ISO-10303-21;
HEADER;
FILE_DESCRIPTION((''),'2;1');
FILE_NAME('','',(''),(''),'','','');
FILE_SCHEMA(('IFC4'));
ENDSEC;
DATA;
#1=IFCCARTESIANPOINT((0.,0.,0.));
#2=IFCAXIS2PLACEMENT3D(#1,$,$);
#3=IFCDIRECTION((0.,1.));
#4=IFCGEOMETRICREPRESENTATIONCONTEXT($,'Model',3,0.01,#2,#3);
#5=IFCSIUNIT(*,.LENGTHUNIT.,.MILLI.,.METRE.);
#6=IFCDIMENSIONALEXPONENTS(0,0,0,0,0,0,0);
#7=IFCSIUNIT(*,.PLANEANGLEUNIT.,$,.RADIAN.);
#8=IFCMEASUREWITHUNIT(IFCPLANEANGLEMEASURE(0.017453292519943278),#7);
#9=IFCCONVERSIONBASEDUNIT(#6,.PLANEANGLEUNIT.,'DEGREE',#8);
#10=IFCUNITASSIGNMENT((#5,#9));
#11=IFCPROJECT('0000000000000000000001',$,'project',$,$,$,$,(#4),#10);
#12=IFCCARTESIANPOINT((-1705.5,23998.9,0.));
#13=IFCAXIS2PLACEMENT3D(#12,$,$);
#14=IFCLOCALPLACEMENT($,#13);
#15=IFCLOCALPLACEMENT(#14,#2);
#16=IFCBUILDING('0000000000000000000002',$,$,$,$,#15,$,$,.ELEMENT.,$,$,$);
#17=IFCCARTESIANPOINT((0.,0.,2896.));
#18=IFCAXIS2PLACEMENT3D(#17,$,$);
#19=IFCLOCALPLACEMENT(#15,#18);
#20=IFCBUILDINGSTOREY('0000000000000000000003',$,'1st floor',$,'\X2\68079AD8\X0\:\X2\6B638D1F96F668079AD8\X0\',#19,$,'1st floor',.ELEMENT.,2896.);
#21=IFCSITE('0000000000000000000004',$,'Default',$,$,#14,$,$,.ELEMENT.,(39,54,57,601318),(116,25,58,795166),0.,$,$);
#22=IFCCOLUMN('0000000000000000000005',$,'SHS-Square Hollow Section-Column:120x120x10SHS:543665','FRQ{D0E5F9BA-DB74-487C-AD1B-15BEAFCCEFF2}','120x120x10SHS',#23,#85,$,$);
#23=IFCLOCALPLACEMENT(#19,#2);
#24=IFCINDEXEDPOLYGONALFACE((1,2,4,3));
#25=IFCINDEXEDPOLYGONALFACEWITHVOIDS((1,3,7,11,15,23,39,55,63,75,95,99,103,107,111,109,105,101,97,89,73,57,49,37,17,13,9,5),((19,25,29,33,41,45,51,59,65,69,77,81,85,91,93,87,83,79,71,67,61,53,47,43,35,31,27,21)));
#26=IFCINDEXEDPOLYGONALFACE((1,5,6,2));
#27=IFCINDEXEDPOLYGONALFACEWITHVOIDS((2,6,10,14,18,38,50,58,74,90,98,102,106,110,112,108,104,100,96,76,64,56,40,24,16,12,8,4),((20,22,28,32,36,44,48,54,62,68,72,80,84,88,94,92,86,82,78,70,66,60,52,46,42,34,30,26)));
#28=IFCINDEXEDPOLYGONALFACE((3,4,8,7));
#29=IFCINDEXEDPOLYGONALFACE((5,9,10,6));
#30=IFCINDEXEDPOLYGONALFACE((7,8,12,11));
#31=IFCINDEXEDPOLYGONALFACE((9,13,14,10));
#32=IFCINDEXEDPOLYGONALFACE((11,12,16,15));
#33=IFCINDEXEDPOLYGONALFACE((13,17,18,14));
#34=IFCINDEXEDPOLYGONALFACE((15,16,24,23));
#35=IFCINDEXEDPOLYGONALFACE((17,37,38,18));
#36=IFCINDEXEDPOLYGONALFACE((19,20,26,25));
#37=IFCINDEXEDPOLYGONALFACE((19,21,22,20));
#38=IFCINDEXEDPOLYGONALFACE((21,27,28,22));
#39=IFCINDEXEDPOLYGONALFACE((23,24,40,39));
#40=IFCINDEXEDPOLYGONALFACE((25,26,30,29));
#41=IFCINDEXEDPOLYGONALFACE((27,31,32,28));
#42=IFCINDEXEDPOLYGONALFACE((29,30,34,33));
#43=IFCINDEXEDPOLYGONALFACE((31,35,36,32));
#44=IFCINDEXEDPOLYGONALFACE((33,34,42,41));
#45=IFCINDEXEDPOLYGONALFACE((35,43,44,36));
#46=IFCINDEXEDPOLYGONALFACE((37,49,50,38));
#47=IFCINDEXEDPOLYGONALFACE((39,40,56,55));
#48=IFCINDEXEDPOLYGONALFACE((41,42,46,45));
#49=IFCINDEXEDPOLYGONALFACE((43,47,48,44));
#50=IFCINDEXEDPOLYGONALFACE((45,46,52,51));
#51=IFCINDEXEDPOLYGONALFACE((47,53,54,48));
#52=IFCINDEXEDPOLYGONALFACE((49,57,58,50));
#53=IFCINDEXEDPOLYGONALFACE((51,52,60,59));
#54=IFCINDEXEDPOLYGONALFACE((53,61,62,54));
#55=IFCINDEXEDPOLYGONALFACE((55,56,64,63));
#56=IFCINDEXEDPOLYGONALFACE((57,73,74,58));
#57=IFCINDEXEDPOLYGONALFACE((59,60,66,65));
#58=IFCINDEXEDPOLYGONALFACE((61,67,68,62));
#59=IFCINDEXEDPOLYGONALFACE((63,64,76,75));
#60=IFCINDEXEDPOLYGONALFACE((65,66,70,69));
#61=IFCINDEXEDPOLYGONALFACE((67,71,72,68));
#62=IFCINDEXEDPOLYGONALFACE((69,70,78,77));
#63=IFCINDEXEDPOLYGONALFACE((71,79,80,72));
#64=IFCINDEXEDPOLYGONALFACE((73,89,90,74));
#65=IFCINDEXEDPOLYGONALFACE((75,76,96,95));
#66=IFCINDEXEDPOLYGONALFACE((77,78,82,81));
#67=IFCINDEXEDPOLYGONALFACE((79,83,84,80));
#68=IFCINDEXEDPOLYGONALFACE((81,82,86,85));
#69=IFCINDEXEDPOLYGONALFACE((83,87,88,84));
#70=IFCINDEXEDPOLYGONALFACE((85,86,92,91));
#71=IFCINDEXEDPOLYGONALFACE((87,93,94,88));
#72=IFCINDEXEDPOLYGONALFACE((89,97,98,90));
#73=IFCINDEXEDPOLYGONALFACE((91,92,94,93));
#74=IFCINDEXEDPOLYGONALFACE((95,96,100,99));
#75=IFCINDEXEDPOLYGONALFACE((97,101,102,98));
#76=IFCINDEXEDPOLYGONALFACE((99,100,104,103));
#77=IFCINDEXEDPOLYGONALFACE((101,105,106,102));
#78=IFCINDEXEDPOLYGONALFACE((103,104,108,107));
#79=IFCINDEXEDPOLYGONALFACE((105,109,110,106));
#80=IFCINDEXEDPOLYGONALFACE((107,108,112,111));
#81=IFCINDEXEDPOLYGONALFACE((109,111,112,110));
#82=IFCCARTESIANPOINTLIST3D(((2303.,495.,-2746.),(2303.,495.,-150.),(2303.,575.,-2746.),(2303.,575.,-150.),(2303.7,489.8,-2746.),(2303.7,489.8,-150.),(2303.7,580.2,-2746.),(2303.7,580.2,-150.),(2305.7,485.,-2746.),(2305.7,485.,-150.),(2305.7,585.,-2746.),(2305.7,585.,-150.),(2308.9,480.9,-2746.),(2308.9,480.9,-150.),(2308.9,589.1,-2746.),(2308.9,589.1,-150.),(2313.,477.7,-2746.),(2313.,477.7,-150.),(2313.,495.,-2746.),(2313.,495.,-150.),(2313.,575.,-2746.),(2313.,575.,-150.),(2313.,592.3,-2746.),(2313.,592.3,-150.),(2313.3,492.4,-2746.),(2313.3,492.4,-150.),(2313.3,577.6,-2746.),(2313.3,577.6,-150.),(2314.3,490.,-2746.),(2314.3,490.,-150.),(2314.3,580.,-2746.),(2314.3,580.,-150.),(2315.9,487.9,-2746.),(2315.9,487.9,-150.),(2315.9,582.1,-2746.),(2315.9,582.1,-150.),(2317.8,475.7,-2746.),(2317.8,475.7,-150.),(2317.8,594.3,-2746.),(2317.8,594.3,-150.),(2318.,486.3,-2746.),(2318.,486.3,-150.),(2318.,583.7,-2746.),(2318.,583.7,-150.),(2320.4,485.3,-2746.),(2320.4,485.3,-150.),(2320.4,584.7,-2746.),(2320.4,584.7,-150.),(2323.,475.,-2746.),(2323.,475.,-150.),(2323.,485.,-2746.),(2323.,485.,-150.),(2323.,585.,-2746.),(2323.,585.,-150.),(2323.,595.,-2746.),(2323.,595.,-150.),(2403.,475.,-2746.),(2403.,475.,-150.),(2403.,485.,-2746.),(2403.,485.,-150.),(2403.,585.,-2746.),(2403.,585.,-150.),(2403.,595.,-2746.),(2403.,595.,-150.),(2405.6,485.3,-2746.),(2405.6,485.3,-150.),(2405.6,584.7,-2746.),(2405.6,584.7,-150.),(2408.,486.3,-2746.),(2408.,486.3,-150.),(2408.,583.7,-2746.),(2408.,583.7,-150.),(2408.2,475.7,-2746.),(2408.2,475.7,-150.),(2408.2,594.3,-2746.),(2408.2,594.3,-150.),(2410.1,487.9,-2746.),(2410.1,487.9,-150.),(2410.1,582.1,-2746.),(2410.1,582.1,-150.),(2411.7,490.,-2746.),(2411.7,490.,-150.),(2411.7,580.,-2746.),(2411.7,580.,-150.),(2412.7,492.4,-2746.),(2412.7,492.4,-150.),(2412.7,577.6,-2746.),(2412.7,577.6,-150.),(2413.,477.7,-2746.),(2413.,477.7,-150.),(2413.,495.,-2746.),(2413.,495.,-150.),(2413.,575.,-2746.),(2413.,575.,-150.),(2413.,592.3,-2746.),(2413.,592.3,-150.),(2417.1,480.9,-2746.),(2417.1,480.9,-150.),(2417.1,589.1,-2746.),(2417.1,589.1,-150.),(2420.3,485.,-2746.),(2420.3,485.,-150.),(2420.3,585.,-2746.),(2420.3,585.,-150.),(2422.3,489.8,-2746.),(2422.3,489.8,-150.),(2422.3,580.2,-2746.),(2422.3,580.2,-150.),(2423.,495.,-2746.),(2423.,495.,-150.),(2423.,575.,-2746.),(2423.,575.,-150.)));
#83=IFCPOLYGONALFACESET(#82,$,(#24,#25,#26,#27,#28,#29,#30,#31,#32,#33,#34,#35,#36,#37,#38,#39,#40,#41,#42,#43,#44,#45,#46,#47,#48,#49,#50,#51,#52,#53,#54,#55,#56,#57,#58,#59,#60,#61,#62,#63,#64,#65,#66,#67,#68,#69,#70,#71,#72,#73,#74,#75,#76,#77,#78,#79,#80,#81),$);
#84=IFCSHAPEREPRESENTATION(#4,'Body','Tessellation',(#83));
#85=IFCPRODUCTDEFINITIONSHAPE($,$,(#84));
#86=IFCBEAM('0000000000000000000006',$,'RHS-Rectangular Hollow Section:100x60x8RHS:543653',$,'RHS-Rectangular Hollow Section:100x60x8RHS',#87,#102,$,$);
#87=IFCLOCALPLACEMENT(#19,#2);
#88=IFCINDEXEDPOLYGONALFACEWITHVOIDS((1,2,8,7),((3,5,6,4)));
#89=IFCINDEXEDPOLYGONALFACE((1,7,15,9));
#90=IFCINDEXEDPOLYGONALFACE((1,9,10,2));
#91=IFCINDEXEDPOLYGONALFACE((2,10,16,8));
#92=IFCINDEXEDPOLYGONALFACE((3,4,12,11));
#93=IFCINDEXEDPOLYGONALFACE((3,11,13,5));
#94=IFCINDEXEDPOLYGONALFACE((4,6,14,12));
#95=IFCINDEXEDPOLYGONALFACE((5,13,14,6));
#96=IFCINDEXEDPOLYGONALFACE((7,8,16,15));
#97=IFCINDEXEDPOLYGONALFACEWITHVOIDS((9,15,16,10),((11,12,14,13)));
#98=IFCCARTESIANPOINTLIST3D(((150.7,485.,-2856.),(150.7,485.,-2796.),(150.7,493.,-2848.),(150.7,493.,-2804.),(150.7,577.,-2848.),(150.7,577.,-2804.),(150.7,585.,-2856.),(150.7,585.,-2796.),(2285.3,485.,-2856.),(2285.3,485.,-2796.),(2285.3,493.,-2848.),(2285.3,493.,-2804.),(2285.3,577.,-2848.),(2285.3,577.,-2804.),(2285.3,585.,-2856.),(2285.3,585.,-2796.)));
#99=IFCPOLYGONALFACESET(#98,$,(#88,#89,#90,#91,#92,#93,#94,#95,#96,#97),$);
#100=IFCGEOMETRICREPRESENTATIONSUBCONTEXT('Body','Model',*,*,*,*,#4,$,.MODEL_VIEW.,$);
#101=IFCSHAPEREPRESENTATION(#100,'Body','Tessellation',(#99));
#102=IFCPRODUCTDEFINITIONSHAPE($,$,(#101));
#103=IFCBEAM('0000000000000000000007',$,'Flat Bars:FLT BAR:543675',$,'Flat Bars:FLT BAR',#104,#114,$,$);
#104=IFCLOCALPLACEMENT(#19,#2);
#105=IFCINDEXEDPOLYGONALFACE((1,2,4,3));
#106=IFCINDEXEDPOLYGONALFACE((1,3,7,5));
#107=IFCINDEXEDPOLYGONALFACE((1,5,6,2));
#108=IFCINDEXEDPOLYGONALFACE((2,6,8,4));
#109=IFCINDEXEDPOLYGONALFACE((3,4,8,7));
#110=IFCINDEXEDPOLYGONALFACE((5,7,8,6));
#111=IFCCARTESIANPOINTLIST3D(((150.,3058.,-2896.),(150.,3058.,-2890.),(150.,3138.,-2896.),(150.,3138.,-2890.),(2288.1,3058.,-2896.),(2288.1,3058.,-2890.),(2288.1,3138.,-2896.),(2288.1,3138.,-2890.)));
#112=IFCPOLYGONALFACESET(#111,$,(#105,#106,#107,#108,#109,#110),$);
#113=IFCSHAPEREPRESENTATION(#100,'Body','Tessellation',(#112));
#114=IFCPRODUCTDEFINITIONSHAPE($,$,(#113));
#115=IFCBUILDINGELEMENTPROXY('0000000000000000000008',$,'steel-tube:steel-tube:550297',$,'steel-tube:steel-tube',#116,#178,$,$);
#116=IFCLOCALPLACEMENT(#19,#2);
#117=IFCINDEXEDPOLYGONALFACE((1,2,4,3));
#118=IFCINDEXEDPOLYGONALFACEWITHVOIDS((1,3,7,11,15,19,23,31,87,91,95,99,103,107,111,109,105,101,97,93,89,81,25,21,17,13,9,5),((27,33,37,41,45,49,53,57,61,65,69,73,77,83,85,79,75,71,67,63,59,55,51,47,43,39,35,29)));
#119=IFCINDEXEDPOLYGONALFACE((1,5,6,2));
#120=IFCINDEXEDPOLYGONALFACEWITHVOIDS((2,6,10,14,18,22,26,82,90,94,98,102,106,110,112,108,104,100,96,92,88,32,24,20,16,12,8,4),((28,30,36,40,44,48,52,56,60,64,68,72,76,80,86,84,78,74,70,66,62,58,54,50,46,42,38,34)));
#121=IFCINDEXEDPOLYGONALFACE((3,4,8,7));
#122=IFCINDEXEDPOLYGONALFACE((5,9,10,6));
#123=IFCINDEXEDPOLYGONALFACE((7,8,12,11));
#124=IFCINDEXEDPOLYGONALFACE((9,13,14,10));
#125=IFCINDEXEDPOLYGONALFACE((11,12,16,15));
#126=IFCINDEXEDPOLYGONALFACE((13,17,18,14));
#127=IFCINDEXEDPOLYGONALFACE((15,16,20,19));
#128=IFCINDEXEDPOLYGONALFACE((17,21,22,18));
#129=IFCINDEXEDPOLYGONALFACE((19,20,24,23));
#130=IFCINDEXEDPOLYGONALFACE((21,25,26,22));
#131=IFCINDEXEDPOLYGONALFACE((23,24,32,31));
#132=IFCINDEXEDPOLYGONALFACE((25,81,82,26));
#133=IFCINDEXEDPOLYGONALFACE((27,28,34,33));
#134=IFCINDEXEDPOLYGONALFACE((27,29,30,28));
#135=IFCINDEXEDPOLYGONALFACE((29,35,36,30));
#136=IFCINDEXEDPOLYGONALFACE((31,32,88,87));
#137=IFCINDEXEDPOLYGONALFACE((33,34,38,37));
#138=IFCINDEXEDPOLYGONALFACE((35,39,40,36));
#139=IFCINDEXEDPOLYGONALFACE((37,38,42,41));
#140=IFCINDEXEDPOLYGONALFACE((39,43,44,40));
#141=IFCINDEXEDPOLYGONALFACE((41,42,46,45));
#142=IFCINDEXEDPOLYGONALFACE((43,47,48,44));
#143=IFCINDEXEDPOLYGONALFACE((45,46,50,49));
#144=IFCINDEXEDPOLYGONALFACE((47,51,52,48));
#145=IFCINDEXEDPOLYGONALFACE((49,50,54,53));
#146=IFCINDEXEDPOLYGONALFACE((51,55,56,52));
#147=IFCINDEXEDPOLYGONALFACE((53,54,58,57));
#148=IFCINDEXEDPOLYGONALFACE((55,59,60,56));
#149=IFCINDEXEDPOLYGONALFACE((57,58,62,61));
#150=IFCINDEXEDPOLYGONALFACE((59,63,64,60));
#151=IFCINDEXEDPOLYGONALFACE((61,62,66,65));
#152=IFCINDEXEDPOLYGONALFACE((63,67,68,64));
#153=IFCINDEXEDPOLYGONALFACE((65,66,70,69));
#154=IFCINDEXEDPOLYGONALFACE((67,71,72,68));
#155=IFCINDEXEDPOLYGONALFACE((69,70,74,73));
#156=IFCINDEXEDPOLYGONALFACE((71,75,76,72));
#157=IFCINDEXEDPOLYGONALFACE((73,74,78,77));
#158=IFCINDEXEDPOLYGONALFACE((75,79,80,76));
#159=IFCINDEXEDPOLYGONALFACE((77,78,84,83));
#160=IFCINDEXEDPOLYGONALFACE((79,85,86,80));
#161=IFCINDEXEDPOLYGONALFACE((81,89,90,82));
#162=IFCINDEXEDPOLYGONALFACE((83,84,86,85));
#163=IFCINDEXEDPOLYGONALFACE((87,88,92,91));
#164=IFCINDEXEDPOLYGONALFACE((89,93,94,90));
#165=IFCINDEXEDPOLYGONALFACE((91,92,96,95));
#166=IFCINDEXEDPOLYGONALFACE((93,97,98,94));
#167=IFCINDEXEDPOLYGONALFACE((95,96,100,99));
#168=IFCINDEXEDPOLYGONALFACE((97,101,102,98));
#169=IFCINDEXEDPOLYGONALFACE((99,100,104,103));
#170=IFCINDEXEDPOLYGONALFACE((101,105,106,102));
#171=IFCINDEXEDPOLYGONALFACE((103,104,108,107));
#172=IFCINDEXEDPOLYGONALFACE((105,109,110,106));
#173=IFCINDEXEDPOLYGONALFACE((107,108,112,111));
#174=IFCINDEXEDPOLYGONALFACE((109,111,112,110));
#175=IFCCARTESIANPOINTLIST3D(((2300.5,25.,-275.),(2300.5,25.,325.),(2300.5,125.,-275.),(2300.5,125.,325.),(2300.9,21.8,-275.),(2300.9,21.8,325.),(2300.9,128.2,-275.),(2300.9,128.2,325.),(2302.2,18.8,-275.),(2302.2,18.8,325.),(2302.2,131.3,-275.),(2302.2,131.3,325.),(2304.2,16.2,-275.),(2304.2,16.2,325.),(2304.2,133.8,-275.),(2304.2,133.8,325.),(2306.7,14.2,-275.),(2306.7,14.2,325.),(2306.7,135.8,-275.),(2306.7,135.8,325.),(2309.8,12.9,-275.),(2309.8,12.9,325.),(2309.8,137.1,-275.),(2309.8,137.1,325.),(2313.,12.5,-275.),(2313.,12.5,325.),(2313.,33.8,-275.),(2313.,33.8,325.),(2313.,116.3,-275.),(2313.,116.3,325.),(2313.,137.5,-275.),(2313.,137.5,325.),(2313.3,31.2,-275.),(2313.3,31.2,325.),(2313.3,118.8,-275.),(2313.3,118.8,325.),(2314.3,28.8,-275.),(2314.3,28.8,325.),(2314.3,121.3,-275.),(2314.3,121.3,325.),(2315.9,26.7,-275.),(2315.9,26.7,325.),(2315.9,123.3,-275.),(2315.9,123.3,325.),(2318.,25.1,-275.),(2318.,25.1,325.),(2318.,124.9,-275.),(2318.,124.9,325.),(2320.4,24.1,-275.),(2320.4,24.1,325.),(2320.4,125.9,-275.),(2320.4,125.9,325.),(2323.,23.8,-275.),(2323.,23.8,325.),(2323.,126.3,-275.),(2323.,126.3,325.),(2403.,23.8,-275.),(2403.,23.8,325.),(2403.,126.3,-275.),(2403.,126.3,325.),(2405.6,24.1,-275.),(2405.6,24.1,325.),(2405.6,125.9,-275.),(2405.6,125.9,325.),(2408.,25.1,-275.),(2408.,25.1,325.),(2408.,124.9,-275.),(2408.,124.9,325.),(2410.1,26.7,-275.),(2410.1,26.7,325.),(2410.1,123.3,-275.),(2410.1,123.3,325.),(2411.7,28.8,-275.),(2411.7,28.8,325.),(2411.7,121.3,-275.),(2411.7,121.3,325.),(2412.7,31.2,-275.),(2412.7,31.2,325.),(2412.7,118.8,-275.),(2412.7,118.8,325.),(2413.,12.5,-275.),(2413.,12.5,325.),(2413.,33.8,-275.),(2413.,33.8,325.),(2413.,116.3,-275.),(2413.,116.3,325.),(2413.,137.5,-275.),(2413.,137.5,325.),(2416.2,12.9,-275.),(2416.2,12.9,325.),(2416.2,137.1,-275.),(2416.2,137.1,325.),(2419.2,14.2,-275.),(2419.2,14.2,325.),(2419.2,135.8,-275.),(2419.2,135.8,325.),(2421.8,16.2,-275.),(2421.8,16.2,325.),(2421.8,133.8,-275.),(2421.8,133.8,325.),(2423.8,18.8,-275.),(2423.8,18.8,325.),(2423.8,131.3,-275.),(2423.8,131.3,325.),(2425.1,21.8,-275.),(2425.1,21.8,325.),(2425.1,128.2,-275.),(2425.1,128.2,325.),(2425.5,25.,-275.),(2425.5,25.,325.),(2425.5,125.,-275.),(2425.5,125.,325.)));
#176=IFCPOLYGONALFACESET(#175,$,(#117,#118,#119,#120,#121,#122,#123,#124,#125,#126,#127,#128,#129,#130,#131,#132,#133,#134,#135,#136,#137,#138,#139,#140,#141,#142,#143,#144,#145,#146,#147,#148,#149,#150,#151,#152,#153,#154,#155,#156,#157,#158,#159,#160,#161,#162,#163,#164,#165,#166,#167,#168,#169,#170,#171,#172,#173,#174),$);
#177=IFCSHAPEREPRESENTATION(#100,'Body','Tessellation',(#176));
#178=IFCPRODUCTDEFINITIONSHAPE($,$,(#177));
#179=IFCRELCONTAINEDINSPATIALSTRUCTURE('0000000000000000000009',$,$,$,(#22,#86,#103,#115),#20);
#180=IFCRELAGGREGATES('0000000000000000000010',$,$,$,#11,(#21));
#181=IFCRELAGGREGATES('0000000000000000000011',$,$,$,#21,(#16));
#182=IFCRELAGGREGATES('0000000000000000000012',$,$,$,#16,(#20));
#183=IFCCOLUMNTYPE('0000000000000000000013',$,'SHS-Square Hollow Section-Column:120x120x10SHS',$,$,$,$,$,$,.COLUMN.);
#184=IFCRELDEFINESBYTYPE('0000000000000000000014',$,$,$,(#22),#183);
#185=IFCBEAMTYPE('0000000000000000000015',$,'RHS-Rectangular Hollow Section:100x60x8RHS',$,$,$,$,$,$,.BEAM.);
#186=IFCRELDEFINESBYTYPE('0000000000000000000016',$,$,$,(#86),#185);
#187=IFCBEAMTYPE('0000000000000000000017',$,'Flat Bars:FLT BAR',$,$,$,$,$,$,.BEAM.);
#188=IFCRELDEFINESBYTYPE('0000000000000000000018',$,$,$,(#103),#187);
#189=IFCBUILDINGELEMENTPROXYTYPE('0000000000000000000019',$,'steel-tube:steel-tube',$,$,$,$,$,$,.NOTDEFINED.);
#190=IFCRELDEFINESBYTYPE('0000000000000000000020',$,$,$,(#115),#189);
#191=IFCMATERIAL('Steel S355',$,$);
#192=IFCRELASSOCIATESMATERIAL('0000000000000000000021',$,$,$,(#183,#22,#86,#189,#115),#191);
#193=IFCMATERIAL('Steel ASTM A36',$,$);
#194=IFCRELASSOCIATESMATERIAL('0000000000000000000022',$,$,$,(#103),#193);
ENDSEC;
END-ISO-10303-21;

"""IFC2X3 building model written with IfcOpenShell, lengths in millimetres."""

from ifc_helpers import new_model, entity, si_unit, converted_unit, direction, frame, frame_2d, origin, origin_2d, origin_2d_with_axis, place, context, subcontext, project, spatial, polyline, circle_curve, parameter, trimmed, segment, composite_curve, rectangle, hollow_rectangle, outline, extrude, boolean, clip, halfspace, source, transform, mapped, material, type_object, type_shapes, element, save


model = new_model("IFC2X3")

# Units and contexts
model_context = context("Model", 3, precision=0.01, world=origin(), true_north=direction((0.0, 1.0)))
body_context = subcontext(model_context, "Body", "Model", "MODEL_VIEW")
ifc_project = project(units=[si_unit("LENGTHUNIT", "METRE", prefix="MILLI"), converted_unit("PLANEANGLEUNIT", "DEGREE", entity("IfcPlaneAngleMeasure", 0.017453292519943278), si_unit("PLANEANGLEUNIT", "RADIAN"), dimensions=[0, 0, 0, 0, 0, 0, 0])], contexts=[model_context])

# Site, building, storey
site_placement = place(None, frame((-1705.5, 23998.9, 0.0)))
site = spatial("IfcSite", under=ifc_project, at=site_placement, Name="Default", CompositionType="ELEMENT", RefLatitude=(39, 54, 57, 601318), RefLongitude=(116, 25, 58, 795166), RefElevation=0.0)
building_placement = place(site_placement, origin())
building = spatial("IfcBuilding", under=site, at=building_placement, CompositionType="ELEMENT")
storey_placement = place(building_placement, frame((0.0, 0.0, 2896.0)))
storey = spatial("IfcBuildingStorey", under=building, at=storey_placement, Name="1st floor", ObjectType="标高:正负零标高", LongName="1st floor", CompositionType="ELEMENT", Elevation=2896.0)

# Shared definitions
ifc_material_1 = material(Name="Steel S355")

# Column
column_type_1 = type_object("IfcColumnType", Name="SHS-Square Hollow Section-Column:120x120x10SHS", PredefinedType="COLUMN", material=ifc_material_1)
column_1_placement = place(storey_placement, frame((2363.0, 535.0, -150.0), z_axis=(0.0, 0.0, 1.0), x_axis=(0.0, -1.0, 0.0)))
element("IfcColumn", 1, at=column_1_placement, inside=storey, type_object=column_type_1, material=ifc_material_1, Name="SHS-Square Hollow Section-Column:120x120x10SHS:543665", Description="FRQ{D0E5F9BA-DB74-487C-AD1B-15BEAFCCEFF2}", ObjectType="120x120x10SHS", context=model_context, shape_type="Clipping", body=[
    clip(extrude(hollow_rectangle(XDim=120.0, YDim=120.0, WallThickness=10.0, InnerFilletRadius=10.0, OuterFilletRadius=20.0, at=origin_2d()), origin(), (0.0, 0.0, -1.0), 2680.9), halfspace(frame((535.0, -2363.0, -2596.0), z_axis=(0.0, 0.0, 1.0), x_axis=(0.0, 1.0, 0.0)), True)),
])

# Beams
beam_type_1 = type_object("IfcBeamType", Name="RHS-Rectangular Hollow Section:100x60x8RHS", PredefinedType="BEAM")
beam_1_placement = place(storey_placement, frame((150.7, 585.0, -2826.0)))
element("IfcBeam", 2, at=beam_1_placement, inside=storey, type_object=beam_type_1, material=ifc_material_1, Name="RHS-Rectangular Hollow Section:100x60x8RHS:543653", ObjectType="RHS-Rectangular Hollow Section:100x60x8RHS", context=body_context, shape_type="SweptSolid", body=[
    boolean("DIFFERENCE", extrude(rectangle(XDim=60.0, YDim=100.0, at=frame_2d((0.0, 0.0), x_axis=(1.0, 0.0))), frame((0.0, -50.0, 0.0), z_axis=(1.0, 0.0, 0.0), x_axis=(0.0, 0.0, -1.0)), (0.0, 0.0, 1.0), 2134.6), extrude(rectangle(XDim=44.0, YDim=84.0, at=frame_2d((0.0, 0.0), x_axis=(0.0, 1.0))), frame((2134.6, -50.0, 0.0), z_axis=(-1.0, 0.0, 0.0), x_axis=(0.0, 1.0, 0.0)), (0.0, 0.0, 1.0), 2134.6)),
])
ifc_material_2 = material(Name="Steel ASTM A36")
beam_type_2 = type_object("IfcBeamType", Name="Flat Bars:FLT BAR", PredefinedType="BEAM")
beam_2_placement = place(storey_placement, frame((150.0, 3098.0, -2890.0)))
element("IfcBeam", 3, at=beam_2_placement, inside=storey, type_object=beam_type_2, material=ifc_material_2, Name="Flat Bars:FLT BAR:543675", ObjectType="Flat Bars:FLT BAR", context=body_context, shape_type="SweptSolid", body=[
    extrude(rectangle(XDim=6.0, YDim=80.0, at=origin_2d_with_axis()), frame((0.0, 0.0, -3.0), z_axis=(1.0, 0.0, 0.0), x_axis=(0.0, 0.0, -1.0)), (0.0, 0.0, 1.0), 2138.1),
])

# Building element proxy
building_element_proxy_type = type_object("IfcBuildingElementProxyType", Name="steel-tube:steel-tube", PredefinedType="NOTDEFINED", material=ifc_material_1)
shared_shape_1 = source(origin(), body_context, "Body", "SweptSolid", [
    extrude(outline(composite_curve([segment(trimmed(circle_curve(frame_2d((50.0, -50.0), x_axis=(1.0, 0.0)), 12.5), [parameter(270.0)], [parameter(0.0)], True, "PARAMETER"), True, "CONTINUOUS"), segment(polyline([(62.5, -50.0), (62.5, 50.0)]), True, "CONTINUOUS"), segment(trimmed(circle_curve(frame_2d((50.0, 50.0), x_axis=(1.0, 0.0)), 12.5), [parameter(0.0)], [parameter(90.0)], True, "PARAMETER"), True, "CONTINUOUS"), segment(polyline([(50.0, 62.5), (-50.0, 62.5)]), True, "CONTINUOUS"), segment(trimmed(circle_curve(frame_2d((-50.0, 50.0), x_axis=(1.0, 0.0)), 12.5), [parameter(90.0)], [parameter(180.0)], True, "PARAMETER"), True, "CONTINUOUS"), segment(polyline([(-62.5, 50.0), (-62.5, -50.0)]), True, "CONTINUOUS"), segment(trimmed(circle_curve(frame_2d((-50.0, -50.0), x_axis=(1.0, 0.0)), 12.5), [parameter(180.0)], [parameter(270.0)], True, "PARAMETER"), True, "CONTINUOUS"), segment(polyline([(-50.0, -62.5), (50.0, -62.5)]), True, "CONTINUOUS")], self_intersect=False), holes=[composite_curve([segment(trimmed(circle_curve(frame_2d((-41.2, 40.0), x_axis=(1.0, 0.0)), 10.0), [parameter(90.0)], [parameter(180.0)], True, "PARAMETER"), False, "CONTINUOUS"), segment(polyline([(-41.3, 50.0), (41.2, 50.0)]), True, "CONTINUOUS"), segment(trimmed(circle_curve(frame_2d((41.2, 40.0), x_axis=(1.0, 0.0)), 10.0), [parameter(0.0)], [parameter(90.0)], True, "PARAMETER"), False, "CONTINUOUS"), segment(polyline([(51.2, 40.0), (51.2, -40.0)]), True, "CONTINUOUS"), segment(trimmed(circle_curve(frame_2d((41.2, -40.0), x_axis=(1.0, 0.0)), 10.0), [parameter(270.0)], [parameter(360.0)], True, "PARAMETER"), False, "CONTINUOUS"), segment(polyline([(41.2, -50.0), (-41.3, -50.0)]), True, "CONTINUOUS"), segment(trimmed(circle_curve(frame_2d((-41.3, -40.0), x_axis=(1.0, 0.0)), 10.0), [parameter(180.0)], [parameter(270.0)], True, "PARAMETER"), False, "CONTINUOUS"), segment(polyline([(-51.3, -40.0), (-51.3, 40.0)]), True, "CONTINUOUS")], self_intersect=False)]), frame((62.5, 62.5, -175.0)), (0.0, 0.0, 1.0), 600.0),
])
type_shapes(building_element_proxy_type, [shared_shape_1])
for number, where, z_axis, x_axis, name in (
    (4, (2300.5, 137.5, -100.0), (0.0, 0.0, 1.0), (0.0, -1.0, 0.0), "steel-tube:steel-tube:550297"),
):
    element("IfcBuildingElementProxy", number, at=place(storey_placement, frame(where, z_axis=z_axis, x_axis=x_axis)), inside=storey, type_object=building_element_proxy_type, material=ifc_material_1, Name=name, ObjectType="steel-tube:steel-tube", context=body_context, shape_type="MappedRepresentation", body=[
        mapped(shared_shape_1, transform((0.0, 0.0, 0.0), scale=1.0)),
    ])

save(model, "model.ifc")
